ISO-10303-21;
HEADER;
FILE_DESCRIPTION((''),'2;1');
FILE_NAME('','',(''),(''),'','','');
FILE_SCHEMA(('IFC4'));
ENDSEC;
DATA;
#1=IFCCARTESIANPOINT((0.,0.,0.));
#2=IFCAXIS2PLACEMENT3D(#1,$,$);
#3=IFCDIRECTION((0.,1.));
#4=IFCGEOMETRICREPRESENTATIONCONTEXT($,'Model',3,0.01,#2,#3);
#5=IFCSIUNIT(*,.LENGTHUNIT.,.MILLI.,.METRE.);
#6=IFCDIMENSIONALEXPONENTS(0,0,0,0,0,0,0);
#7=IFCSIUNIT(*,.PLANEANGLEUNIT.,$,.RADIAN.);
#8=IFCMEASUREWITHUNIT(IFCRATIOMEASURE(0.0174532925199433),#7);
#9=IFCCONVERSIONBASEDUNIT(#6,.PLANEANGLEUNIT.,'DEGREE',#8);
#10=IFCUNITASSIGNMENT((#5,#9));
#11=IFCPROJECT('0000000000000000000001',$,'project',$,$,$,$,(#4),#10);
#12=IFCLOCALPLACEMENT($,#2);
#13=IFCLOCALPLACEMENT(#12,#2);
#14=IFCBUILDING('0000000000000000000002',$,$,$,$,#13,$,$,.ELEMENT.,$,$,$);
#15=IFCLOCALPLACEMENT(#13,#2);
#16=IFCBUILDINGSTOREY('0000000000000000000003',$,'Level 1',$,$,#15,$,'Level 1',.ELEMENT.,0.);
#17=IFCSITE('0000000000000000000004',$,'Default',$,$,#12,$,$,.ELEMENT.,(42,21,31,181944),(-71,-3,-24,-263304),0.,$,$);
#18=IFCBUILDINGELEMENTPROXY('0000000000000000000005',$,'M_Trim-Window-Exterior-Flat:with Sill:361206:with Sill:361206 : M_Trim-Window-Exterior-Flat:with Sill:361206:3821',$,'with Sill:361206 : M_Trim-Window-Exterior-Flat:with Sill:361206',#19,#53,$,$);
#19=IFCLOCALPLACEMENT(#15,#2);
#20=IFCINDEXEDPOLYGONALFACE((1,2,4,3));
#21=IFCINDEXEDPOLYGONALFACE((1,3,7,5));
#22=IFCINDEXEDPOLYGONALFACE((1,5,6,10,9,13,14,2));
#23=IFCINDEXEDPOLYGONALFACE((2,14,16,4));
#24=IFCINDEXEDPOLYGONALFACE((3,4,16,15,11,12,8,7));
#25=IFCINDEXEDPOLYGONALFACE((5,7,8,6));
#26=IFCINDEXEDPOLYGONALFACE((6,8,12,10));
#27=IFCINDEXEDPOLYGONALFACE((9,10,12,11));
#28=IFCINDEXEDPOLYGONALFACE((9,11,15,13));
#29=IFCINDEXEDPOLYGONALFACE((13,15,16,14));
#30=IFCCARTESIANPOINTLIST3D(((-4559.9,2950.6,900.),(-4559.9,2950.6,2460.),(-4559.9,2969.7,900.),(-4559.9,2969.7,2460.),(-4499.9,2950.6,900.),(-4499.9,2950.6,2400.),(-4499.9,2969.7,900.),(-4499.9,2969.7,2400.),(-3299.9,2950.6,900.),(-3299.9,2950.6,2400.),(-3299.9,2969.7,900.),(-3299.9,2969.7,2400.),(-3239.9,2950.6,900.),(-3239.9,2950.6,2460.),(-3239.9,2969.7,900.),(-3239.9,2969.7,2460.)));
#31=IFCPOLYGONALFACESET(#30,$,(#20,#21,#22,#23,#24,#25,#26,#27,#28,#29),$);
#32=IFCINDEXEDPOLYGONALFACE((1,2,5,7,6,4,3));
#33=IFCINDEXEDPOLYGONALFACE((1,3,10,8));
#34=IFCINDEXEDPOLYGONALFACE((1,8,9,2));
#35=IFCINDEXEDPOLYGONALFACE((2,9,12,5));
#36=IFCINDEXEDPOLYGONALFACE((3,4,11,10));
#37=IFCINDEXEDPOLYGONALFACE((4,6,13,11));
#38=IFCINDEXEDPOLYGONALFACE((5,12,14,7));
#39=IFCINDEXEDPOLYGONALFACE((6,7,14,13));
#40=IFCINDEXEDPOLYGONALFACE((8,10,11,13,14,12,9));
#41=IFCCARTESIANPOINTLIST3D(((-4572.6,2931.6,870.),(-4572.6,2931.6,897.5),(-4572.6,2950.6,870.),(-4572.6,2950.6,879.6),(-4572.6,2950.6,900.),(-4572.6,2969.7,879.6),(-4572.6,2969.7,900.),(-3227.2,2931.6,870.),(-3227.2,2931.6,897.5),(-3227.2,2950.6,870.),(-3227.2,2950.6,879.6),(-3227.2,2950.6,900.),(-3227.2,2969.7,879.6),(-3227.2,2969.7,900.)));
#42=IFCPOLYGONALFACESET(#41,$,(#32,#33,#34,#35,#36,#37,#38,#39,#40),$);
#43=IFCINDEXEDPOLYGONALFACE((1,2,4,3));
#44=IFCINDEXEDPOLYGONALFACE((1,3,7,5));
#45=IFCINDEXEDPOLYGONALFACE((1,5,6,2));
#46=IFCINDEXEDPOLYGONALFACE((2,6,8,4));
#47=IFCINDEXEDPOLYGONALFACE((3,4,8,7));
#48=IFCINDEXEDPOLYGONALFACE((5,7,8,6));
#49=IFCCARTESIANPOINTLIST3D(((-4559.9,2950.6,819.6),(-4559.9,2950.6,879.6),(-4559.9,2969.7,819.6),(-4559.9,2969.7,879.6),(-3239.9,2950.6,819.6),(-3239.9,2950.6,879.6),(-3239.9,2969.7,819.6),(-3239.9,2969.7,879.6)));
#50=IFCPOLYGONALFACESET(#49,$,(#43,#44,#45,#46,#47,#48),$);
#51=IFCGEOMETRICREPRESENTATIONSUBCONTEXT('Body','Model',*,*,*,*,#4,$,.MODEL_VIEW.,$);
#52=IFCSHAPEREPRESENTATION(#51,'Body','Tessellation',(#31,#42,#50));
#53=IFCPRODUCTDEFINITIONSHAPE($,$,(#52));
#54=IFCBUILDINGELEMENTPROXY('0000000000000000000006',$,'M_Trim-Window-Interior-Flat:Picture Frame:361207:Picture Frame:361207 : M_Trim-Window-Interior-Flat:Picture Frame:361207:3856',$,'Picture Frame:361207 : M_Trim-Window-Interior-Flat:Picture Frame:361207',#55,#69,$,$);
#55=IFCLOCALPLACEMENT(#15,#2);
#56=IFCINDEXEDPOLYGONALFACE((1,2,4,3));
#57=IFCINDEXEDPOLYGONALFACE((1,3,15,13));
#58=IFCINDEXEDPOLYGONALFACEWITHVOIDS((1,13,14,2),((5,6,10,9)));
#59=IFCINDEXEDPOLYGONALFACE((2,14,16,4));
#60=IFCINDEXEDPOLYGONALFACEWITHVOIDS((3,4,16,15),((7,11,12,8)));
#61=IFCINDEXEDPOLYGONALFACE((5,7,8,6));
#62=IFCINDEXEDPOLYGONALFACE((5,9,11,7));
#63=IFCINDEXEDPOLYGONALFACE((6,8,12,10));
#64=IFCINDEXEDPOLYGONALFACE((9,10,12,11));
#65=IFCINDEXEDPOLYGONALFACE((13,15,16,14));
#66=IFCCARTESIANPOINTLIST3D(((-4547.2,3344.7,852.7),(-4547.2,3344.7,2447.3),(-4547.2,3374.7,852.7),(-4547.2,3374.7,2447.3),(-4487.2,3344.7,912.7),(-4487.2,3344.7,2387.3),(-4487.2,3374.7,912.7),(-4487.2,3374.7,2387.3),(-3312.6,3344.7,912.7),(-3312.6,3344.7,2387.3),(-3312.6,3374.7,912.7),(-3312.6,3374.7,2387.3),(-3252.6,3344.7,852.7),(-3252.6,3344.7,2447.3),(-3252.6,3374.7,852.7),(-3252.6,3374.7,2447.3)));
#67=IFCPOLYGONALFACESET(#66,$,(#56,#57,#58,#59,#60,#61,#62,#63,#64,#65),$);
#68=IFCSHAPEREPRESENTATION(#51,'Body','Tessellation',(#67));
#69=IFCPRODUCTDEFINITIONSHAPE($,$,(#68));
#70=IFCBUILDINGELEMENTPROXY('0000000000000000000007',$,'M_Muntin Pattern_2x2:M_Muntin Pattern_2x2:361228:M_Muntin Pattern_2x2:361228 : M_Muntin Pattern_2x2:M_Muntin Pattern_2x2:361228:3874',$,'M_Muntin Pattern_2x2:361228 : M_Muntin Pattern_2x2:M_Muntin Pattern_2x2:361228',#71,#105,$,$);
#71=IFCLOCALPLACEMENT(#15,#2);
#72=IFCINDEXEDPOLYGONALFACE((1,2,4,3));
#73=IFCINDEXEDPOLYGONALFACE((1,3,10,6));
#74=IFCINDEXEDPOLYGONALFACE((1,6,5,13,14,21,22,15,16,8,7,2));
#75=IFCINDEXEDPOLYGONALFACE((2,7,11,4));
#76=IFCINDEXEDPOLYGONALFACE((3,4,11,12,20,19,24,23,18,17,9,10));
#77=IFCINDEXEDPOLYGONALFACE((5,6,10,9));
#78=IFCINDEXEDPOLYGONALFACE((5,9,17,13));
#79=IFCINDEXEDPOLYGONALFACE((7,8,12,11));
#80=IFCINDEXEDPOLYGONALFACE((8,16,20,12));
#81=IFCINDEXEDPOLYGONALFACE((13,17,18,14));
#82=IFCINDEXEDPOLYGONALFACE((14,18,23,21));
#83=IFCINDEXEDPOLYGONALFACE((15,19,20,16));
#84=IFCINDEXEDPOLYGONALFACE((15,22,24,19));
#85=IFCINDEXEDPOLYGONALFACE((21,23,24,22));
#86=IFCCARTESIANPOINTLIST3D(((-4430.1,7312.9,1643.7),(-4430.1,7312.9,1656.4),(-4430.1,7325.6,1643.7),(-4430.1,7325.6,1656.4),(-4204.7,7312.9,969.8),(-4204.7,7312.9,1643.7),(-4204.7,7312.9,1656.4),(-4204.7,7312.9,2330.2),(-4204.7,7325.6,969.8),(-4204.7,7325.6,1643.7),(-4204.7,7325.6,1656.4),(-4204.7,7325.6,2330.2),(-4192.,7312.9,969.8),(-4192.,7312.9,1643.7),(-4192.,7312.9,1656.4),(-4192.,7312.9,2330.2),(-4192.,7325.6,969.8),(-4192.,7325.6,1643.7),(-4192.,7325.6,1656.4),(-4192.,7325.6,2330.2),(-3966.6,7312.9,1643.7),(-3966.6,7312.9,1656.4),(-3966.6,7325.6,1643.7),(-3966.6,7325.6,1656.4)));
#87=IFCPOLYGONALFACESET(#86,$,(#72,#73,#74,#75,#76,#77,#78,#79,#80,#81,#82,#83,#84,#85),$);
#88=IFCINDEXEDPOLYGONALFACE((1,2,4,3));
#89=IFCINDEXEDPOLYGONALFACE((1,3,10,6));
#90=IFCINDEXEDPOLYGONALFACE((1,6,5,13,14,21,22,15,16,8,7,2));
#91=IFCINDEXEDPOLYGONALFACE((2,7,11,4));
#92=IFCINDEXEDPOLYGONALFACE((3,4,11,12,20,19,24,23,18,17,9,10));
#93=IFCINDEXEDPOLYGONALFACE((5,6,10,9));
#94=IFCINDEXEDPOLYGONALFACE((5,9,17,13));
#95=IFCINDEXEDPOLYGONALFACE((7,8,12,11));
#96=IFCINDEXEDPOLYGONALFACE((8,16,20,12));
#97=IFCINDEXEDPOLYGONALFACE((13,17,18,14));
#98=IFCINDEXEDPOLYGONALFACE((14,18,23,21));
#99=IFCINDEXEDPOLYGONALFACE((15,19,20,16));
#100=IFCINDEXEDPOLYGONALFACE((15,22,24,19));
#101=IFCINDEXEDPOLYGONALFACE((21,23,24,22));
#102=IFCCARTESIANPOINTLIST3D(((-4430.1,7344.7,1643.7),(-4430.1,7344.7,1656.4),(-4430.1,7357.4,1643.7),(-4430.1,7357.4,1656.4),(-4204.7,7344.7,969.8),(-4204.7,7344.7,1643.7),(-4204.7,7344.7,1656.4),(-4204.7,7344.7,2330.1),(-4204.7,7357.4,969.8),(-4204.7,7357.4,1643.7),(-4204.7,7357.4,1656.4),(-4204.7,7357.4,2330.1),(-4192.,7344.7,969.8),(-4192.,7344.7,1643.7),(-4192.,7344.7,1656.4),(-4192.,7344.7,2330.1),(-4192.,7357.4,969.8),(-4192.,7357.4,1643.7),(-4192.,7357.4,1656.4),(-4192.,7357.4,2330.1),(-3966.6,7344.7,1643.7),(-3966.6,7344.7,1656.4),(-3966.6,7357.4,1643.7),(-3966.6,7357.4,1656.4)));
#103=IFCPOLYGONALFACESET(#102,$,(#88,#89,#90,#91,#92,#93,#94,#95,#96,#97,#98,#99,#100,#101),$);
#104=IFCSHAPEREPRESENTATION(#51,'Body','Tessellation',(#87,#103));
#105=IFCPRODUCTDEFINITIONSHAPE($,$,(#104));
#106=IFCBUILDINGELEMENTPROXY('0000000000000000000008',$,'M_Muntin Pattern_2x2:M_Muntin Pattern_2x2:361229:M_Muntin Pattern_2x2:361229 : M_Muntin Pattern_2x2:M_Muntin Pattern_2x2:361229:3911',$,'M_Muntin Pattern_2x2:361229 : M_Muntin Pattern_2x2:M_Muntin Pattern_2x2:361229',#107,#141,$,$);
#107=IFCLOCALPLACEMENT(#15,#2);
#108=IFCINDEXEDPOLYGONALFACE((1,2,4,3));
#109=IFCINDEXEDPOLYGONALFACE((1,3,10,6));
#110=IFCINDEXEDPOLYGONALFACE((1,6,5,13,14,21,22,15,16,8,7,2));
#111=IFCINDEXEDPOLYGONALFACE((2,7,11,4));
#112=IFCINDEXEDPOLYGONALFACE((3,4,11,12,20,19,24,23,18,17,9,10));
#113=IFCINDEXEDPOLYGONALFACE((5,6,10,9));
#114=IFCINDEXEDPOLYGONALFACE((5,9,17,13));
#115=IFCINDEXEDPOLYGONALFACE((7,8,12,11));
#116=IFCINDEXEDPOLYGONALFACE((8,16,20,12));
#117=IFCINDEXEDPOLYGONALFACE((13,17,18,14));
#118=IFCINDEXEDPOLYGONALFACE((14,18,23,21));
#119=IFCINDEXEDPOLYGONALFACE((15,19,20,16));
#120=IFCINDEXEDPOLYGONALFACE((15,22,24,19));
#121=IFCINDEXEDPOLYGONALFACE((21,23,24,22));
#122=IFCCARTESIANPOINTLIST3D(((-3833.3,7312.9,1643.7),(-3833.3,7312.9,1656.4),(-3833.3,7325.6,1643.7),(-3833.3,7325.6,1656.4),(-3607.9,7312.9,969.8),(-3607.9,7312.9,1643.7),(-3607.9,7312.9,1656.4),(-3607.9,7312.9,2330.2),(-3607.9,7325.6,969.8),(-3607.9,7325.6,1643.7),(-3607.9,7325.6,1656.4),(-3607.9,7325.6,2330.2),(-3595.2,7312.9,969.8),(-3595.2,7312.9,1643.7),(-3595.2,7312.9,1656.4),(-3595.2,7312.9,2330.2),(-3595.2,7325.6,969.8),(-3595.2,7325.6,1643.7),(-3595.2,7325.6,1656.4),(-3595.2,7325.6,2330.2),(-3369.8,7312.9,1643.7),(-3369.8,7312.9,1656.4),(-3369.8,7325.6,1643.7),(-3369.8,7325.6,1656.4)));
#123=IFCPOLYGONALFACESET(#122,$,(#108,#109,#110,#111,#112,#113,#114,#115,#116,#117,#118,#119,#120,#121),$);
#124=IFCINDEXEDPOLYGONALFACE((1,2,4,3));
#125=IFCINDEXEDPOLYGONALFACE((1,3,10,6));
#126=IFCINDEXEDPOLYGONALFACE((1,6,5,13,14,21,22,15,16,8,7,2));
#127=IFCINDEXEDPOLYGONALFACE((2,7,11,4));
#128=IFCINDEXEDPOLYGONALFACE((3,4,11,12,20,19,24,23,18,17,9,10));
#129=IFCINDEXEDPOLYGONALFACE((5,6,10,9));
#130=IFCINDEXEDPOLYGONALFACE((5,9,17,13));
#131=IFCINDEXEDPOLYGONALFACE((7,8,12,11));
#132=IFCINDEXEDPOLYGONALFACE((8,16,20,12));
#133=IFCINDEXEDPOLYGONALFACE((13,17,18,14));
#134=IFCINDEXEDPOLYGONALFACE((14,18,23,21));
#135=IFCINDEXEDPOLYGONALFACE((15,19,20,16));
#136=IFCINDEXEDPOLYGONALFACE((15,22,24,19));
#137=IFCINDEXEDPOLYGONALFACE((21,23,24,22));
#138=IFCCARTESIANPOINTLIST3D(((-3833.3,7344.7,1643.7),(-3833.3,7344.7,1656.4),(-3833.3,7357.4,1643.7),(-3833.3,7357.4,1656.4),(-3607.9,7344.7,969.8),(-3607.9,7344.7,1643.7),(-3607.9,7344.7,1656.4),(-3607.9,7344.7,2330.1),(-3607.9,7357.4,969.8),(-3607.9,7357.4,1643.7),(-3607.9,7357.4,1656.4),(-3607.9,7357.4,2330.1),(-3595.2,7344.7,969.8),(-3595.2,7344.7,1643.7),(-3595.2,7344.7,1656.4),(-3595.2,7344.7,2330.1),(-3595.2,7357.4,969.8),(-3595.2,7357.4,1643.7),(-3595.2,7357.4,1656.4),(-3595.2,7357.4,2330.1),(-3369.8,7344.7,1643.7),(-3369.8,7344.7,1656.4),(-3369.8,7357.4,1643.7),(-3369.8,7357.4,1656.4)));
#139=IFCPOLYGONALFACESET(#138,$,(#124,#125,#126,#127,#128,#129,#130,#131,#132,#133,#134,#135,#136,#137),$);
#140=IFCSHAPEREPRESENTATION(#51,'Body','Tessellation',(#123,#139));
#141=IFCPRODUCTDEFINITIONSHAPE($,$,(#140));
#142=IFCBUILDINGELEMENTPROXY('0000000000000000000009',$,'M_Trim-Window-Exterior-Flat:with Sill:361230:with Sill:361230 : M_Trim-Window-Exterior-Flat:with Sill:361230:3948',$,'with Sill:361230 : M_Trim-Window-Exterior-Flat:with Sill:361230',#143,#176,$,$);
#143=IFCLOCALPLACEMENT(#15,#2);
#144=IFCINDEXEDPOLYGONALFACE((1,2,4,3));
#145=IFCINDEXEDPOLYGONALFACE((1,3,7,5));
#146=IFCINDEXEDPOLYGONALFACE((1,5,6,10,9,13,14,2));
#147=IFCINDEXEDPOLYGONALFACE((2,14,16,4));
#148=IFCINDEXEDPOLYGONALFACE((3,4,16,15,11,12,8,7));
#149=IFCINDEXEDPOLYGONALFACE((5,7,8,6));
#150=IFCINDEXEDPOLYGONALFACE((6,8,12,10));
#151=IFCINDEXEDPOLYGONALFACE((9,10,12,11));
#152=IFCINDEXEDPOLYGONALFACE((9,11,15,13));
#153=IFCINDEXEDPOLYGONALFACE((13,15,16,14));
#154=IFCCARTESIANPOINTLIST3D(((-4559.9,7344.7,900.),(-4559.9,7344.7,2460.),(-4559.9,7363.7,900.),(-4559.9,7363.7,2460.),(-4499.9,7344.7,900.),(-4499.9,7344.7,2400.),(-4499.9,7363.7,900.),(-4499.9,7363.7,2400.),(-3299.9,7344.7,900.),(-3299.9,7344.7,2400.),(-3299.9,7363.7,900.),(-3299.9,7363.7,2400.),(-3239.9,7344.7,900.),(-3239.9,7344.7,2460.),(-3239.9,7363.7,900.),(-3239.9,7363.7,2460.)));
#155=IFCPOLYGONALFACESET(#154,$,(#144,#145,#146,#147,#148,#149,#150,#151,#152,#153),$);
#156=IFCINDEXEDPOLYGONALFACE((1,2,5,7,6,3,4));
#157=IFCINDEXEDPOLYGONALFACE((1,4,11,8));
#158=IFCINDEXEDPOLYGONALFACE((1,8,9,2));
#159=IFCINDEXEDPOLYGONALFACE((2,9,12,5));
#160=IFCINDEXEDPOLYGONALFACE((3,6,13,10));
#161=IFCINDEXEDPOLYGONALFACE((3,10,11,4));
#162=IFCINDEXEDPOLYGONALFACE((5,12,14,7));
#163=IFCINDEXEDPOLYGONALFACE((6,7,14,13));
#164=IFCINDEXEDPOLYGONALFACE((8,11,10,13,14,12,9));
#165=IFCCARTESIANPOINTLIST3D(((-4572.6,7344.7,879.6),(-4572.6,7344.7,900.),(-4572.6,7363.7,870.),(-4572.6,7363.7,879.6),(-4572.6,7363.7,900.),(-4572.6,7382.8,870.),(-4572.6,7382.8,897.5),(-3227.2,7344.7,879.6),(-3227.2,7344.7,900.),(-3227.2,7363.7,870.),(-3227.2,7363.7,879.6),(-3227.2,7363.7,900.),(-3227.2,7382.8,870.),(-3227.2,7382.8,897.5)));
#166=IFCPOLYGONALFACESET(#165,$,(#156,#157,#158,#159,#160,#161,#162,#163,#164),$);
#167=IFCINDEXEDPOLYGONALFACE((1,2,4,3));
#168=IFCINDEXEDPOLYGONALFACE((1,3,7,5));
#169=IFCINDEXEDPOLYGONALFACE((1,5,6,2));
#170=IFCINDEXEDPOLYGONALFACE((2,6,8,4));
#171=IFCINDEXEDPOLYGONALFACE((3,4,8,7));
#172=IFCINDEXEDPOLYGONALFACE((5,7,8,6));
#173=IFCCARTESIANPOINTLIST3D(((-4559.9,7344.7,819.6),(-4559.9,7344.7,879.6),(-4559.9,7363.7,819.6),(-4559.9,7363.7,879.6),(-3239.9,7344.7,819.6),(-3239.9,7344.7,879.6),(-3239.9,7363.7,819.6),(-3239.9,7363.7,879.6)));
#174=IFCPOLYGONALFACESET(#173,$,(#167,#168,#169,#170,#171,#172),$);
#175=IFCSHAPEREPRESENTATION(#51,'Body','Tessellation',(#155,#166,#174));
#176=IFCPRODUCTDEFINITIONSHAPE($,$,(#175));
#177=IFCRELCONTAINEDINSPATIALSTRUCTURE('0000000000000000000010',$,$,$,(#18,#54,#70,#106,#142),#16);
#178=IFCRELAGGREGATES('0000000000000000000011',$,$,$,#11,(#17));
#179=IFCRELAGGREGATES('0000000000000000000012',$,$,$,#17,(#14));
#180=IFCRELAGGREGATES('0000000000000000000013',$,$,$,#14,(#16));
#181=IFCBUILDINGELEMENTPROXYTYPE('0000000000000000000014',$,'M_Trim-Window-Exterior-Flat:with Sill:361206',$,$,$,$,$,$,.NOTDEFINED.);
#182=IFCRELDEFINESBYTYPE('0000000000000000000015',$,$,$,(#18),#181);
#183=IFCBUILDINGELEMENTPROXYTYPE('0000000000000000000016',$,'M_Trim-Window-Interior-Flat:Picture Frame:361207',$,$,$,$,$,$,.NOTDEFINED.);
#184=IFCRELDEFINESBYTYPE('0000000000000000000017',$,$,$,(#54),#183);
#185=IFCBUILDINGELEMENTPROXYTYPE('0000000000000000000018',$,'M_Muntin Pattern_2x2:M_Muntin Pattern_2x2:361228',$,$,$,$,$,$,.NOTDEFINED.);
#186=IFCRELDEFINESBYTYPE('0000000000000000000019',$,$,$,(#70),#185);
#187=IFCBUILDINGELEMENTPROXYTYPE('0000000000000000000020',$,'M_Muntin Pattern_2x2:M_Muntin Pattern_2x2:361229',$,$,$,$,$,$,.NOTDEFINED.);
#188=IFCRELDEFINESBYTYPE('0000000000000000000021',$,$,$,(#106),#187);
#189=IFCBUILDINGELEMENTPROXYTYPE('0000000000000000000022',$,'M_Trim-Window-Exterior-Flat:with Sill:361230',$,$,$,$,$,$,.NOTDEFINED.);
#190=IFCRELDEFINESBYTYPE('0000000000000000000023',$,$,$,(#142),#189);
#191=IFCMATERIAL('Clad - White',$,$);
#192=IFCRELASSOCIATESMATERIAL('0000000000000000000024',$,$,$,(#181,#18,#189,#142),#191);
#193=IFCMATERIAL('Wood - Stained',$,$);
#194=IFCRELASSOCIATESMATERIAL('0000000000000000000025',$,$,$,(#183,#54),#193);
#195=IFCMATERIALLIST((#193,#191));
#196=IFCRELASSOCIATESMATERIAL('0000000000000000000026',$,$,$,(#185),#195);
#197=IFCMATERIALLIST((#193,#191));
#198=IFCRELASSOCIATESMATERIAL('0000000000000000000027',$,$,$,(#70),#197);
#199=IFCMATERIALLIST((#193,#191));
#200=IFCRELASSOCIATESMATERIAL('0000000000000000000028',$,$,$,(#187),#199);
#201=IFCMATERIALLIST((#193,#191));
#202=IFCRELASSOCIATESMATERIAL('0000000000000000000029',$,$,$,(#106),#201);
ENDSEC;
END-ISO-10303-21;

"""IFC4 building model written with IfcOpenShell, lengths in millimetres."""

from ifc_helpers import new_model, entity, si_unit, converted_unit, direction, frame, origin, origin_2d_with_axis, place, context, subcontext, project, spatial, polyline, rectangle, outline, extrude, source, transform, mapped, material, material_list, type_object, type_shapes, element, save


model = new_model("IFC4")

# Units and contexts
model_context = context("Model", 3, precision=0.01, world=origin(), true_north=direction((0.0, 1.0)))
body_context = subcontext(model_context, "Body", "Model", "MODEL_VIEW")
ifc_project = project(units=[si_unit("LENGTHUNIT", "METRE", prefix="MILLI"), converted_unit("PLANEANGLEUNIT", "DEGREE", entity("IfcRatioMeasure", 0.0174532925199433), si_unit("PLANEANGLEUNIT", "RADIAN"), dimensions=[0, 0, 0, 0, 0, 0, 0])], contexts=[model_context])

# Site, building, storey
site_placement = place(None, origin())
site = spatial("IfcSite", under=ifc_project, at=site_placement, Name="Default", CompositionType="ELEMENT", RefLatitude=(42, 21, 31, 181944), RefLongitude=(-71, -3, -24, -263304), RefElevation=0.0)
building_placement = place(site_placement, origin())
building = spatial("IfcBuilding", under=site, at=building_placement, CompositionType="ELEMENT")
storey_placement = place(building_placement, origin())
storey = spatial("IfcBuildingStorey", under=building, at=storey_placement, Name="Level 1", LongName="Level 1", CompositionType="ELEMENT", Elevation=0.0)

# Building element proxies
ifc_material_1 = material(Name="Wood - Stained")
ifc_material_2 = material(Name="Clad - White")
building_element_proxy_type_1 = type_object("IfcBuildingElementProxyType", Name="M_Trim-Window-Exterior-Flat:with Sill:361206", PredefinedType="NOTDEFINED", material=ifc_material_2)
shared_shape_1 = source(origin(), body_context, "Body", "SweptSolid", [
    extrude(outline(polyline([(-765.0, -660.0), (795.0, -660.0), (795.0, 660.0), (-765.0, 660.0), (-765.0, 600.0), (735.0, 600.0), (735.0, -600.0), (-765.0, -600.0), (-765.0, -660.0)])), frame((-3899.9, 2950.6, 1665.0), z_axis=(0.0, 1.0, 0.0), x_axis=(0.0, 0.0, 1.0)), (0.0, 0.0, 1.0), 19.1),
    extrude(outline(polyline([(-15.2, 0.0), (-15.2, -19.0), (12.3, -19.0), (14.8, 0.0), (14.8, 19.0), (-5.7, 19.0), (-5.7, 0.0), (-15.2, 0.0)])), frame((-4572.6, 2950.6, 885.2), z_axis=(-1.0, 0.0, 0.0), x_axis=(0.0, 0.0, 1.0)), (0.0, 0.0, -1.0), 1345.4),
    extrude(rectangle(XDim=19.1, YDim=1320.0, at=origin_2d_with_axis()), frame((-3899.9, 2960.1, 819.6), z_axis=(0.0, 0.0, 1.0), x_axis=(0.0, 1.0, 0.0)), (0.0, 0.0, 1.0), 60.0),
])
type_shapes(building_element_proxy_type_1, [shared_shape_1])
proxy_1_placement = place(storey_placement, origin())
element("IfcBuildingElementProxy", 1, at=proxy_1_placement, inside=storey, type_object=building_element_proxy_type_1, material=ifc_material_2, Name="M_Trim-Window-Exterior-Flat:with Sill:361206:with Sill:361206 : M_Trim-Window-Exterior-Flat:with Sill:361206:3821", ObjectType="with Sill:361206 : M_Trim-Window-Exterior-Flat:with Sill:361206", context=body_context, shape_type="MappedRepresentation", body=[
    mapped(shared_shape_1, transform((0.0, 0.0, 0.0), scale=1.0)),
])
building_element_proxy_type_2 = type_object("IfcBuildingElementProxyType", Name="M_Trim-Window-Interior-Flat:Picture Frame:361207", PredefinedType="NOTDEFINED", material=ifc_material_1)
shared_shape_2 = source(origin(), body_context, "Body", "SweptSolid", [
    extrude(outline(polyline([(-797.3, -647.3), (797.3, -647.3), (797.3, 647.3), (-797.3, 647.3), (-797.3, -647.3)]), holes=[polyline([(737.3, 587.3), (737.3, -587.3), (-737.3, -587.3), (-737.3, 587.3), (737.3, 587.3)])]), frame((-3899.9, 3344.7, 1650.0), z_axis=(0.0, 1.0, 0.0), x_axis=(0.0, 0.0, -1.0)), (0.0, 0.0, 1.0), 30.0),
])
type_shapes(building_element_proxy_type_2, [shared_shape_2])
proxy_2_placement = place(storey_placement, origin())
element("IfcBuildingElementProxy", 2, at=proxy_2_placement, inside=storey, type_object=building_element_proxy_type_2, material=ifc_material_1, Name="M_Trim-Window-Interior-Flat:Picture Frame:361207:Picture Frame:361207 : M_Trim-Window-Interior-Flat:Picture Frame:361207:3856", ObjectType="Picture Frame:361207 : M_Trim-Window-Interior-Flat:Picture Frame:361207", context=body_context, shape_type="MappedRepresentation", body=[
    mapped(shared_shape_2, transform((0.0, 0.0, 0.0), scale=1.0)),
])
ifc_material_list_1 = material_list([ifc_material_1, ifc_material_2])
ifc_material_list_2 = material_list([ifc_material_1, ifc_material_2])
building_element_proxy_type_3 = type_object("IfcBuildingElementProxyType", Name="M_Muntin Pattern_2x2:M_Muntin Pattern_2x2:361228", PredefinedType="NOTDEFINED", material=ifc_material_list_2)
shared_shape_3 = source(origin(), body_context, "Body", "SweptSolid", [
    extrude(outline(polyline([(-6.4, -680.2), (6.3, -680.2), (6.3, -6.4), (231.7, -6.4), (231.7, 6.3), (6.3, 6.3), (6.3, 680.2), (-6.4, 680.2), (-6.4, 6.3), (-231.7, 6.3), (-231.7, -6.4), (-6.4, -6.4), (-6.4, -680.2)])), frame((-4198.4, 7312.9, 1650.0), z_axis=(0.0, 1.0, 0.0), x_axis=(1.0, 0.0, 0.0)), (0.0, 0.0, 1.0), 12.7),
    extrude(outline(polyline([(-6.4, -680.1), (6.3, -680.1), (6.3, -6.4), (231.7, -6.4), (231.7, 6.3), (6.3, 6.3), (6.3, 680.2), (-6.4, 680.2), (-6.4, 6.3), (-231.7, 6.3), (-231.7, -6.4), (-6.4, -6.4), (-6.4, -680.1)])), frame((-4198.4, 7344.7, 1650.0), z_axis=(0.0, 1.0, 0.0), x_axis=(1.0, 0.0, 0.0)), (0.0, 0.0, 1.0), 12.7),
])
type_shapes(building_element_proxy_type_3, [shared_shape_3])
proxy_3_placement = place(storey_placement, origin())
element("IfcBuildingElementProxy", 3, at=proxy_3_placement, inside=storey, type_object=building_element_proxy_type_3, material=ifc_material_list_1, Name="M_Muntin Pattern_2x2:M_Muntin Pattern_2x2:361228:M_Muntin Pattern_2x2:361228 : M_Muntin Pattern_2x2:M_Muntin Pattern_2x2:361228:3874", ObjectType="M_Muntin Pattern_2x2:361228 : M_Muntin Pattern_2x2:M_Muntin Pattern_2x2:361228", context=body_context, shape_type="MappedRepresentation", body=[
    mapped(shared_shape_3, transform((0.0, 0.0, 0.0), scale=1.0)),
])
ifc_material_list_3 = material_list([ifc_material_1, ifc_material_2])
ifc_material_list_4 = material_list([ifc_material_1, ifc_material_2])
building_element_proxy_type_4 = type_object("IfcBuildingElementProxyType", Name="M_Muntin Pattern_2x2:M_Muntin Pattern_2x2:361229", PredefinedType="NOTDEFINED", material=ifc_material_list_4)
shared_shape_4 = source(origin(), body_context, "Body", "SweptSolid", [
    extrude(outline(polyline([(-680.1, 6.4), (-680.1, -6.3), (-6.4, -6.3), (-6.4, -231.7), (6.3, -231.7), (6.3, -6.3), (680.2, -6.3), (680.2, 6.4), (6.3, 6.4), (6.3, 231.7), (-6.4, 231.7), (-6.4, 6.4), (-680.1, 6.4)])), frame((-3601.5, 7312.9, 1650.0), z_axis=(0.0, -1.0, 0.0), x_axis=(0.0, 0.0, -1.0)), (0.0, 0.0, -1.0), 12.7),
    extrude(outline(polyline([(-680.1, 6.4), (-680.1, -6.3), (-6.4, -6.3), (-6.4, -231.7), (6.3, -231.7), (6.3, -6.3), (680.2, -6.3), (680.2, 6.4), (6.3, 6.4), (6.3, 231.7), (-6.4, 231.7), (-6.4, 6.4), (-680.1, 6.4)])), frame((-3601.5, 7344.7, 1650.0), z_axis=(0.0, -1.0, 0.0), x_axis=(0.0, 0.0, -1.0)), (0.0, 0.0, -1.0), 12.7),
])
type_shapes(building_element_proxy_type_4, [shared_shape_4])
proxy_4_placement = place(storey_placement, origin())
element("IfcBuildingElementProxy", 4, at=proxy_4_placement, inside=storey, type_object=building_element_proxy_type_4, material=ifc_material_list_3, Name="M_Muntin Pattern_2x2:M_Muntin Pattern_2x2:361229:M_Muntin Pattern_2x2:361229 : M_Muntin Pattern_2x2:M_Muntin Pattern_2x2:361229:3911", ObjectType="M_Muntin Pattern_2x2:361229 : M_Muntin Pattern_2x2:M_Muntin Pattern_2x2:361229", context=body_context, shape_type="MappedRepresentation", body=[
    mapped(shared_shape_4, transform((0.0, 0.0, 0.0), scale=1.0)),
])
building_element_proxy_type_5 = type_object("IfcBuildingElementProxyType", Name="M_Trim-Window-Exterior-Flat:with Sill:361230", PredefinedType="NOTDEFINED", material=ifc_material_2)
shared_shape_5 = source(origin(), body_context, "Body", "SweptSolid", [
    extrude(outline(polyline([(-660.0, -765.0), (-600.0, -765.0), (-600.0, 735.0), (600.0, 735.0), (600.0, -765.0), (660.0, -765.0), (660.0, 795.0), (-660.0, 795.0), (-660.0, -765.0)])), frame((-3899.9, 7344.7, 1665.0), z_axis=(0.0, 1.0, 0.0), x_axis=(-1.0, 0.0, 0.0)), (0.0, 0.0, 1.0), 19.1),
    extrude(outline(polyline([(0.0, -15.2), (19.0, -15.2), (19.0, 12.3), (0.0, 14.8), (-19.0, 14.8), (-19.0, -5.7), (0.0, -5.7), (0.0, -15.2)])), frame((-4572.6, 7363.7, 885.2), z_axis=(1.0, 0.0, 0.0), x_axis=(0.0, 1.0, 0.0)), (0.0, 0.0, 1.0), 1345.4),
    extrude(rectangle(XDim=19.1, YDim=1320.0, at=origin_2d_with_axis()), frame((-3899.9, 7354.2, 819.6), z_axis=(0.0, 0.0, 1.0), x_axis=(0.0, -1.0, 0.0)), (0.0, 0.0, 1.0), 60.0),
])
type_shapes(building_element_proxy_type_5, [shared_shape_5])
proxy_5_placement = place(storey_placement, origin())
element("IfcBuildingElementProxy", 5, at=proxy_5_placement, inside=storey, type_object=building_element_proxy_type_5, material=ifc_material_2, Name="M_Trim-Window-Exterior-Flat:with Sill:361230:with Sill:361230 : M_Trim-Window-Exterior-Flat:with Sill:361230:3948", ObjectType="with Sill:361230 : M_Trim-Window-Exterior-Flat:with Sill:361230", context=body_context, shape_type="MappedRepresentation", body=[
    mapped(shared_shape_5, transform((0.0, 0.0, 0.0), scale=1.0)),
])

save(model, "model.ifc")
